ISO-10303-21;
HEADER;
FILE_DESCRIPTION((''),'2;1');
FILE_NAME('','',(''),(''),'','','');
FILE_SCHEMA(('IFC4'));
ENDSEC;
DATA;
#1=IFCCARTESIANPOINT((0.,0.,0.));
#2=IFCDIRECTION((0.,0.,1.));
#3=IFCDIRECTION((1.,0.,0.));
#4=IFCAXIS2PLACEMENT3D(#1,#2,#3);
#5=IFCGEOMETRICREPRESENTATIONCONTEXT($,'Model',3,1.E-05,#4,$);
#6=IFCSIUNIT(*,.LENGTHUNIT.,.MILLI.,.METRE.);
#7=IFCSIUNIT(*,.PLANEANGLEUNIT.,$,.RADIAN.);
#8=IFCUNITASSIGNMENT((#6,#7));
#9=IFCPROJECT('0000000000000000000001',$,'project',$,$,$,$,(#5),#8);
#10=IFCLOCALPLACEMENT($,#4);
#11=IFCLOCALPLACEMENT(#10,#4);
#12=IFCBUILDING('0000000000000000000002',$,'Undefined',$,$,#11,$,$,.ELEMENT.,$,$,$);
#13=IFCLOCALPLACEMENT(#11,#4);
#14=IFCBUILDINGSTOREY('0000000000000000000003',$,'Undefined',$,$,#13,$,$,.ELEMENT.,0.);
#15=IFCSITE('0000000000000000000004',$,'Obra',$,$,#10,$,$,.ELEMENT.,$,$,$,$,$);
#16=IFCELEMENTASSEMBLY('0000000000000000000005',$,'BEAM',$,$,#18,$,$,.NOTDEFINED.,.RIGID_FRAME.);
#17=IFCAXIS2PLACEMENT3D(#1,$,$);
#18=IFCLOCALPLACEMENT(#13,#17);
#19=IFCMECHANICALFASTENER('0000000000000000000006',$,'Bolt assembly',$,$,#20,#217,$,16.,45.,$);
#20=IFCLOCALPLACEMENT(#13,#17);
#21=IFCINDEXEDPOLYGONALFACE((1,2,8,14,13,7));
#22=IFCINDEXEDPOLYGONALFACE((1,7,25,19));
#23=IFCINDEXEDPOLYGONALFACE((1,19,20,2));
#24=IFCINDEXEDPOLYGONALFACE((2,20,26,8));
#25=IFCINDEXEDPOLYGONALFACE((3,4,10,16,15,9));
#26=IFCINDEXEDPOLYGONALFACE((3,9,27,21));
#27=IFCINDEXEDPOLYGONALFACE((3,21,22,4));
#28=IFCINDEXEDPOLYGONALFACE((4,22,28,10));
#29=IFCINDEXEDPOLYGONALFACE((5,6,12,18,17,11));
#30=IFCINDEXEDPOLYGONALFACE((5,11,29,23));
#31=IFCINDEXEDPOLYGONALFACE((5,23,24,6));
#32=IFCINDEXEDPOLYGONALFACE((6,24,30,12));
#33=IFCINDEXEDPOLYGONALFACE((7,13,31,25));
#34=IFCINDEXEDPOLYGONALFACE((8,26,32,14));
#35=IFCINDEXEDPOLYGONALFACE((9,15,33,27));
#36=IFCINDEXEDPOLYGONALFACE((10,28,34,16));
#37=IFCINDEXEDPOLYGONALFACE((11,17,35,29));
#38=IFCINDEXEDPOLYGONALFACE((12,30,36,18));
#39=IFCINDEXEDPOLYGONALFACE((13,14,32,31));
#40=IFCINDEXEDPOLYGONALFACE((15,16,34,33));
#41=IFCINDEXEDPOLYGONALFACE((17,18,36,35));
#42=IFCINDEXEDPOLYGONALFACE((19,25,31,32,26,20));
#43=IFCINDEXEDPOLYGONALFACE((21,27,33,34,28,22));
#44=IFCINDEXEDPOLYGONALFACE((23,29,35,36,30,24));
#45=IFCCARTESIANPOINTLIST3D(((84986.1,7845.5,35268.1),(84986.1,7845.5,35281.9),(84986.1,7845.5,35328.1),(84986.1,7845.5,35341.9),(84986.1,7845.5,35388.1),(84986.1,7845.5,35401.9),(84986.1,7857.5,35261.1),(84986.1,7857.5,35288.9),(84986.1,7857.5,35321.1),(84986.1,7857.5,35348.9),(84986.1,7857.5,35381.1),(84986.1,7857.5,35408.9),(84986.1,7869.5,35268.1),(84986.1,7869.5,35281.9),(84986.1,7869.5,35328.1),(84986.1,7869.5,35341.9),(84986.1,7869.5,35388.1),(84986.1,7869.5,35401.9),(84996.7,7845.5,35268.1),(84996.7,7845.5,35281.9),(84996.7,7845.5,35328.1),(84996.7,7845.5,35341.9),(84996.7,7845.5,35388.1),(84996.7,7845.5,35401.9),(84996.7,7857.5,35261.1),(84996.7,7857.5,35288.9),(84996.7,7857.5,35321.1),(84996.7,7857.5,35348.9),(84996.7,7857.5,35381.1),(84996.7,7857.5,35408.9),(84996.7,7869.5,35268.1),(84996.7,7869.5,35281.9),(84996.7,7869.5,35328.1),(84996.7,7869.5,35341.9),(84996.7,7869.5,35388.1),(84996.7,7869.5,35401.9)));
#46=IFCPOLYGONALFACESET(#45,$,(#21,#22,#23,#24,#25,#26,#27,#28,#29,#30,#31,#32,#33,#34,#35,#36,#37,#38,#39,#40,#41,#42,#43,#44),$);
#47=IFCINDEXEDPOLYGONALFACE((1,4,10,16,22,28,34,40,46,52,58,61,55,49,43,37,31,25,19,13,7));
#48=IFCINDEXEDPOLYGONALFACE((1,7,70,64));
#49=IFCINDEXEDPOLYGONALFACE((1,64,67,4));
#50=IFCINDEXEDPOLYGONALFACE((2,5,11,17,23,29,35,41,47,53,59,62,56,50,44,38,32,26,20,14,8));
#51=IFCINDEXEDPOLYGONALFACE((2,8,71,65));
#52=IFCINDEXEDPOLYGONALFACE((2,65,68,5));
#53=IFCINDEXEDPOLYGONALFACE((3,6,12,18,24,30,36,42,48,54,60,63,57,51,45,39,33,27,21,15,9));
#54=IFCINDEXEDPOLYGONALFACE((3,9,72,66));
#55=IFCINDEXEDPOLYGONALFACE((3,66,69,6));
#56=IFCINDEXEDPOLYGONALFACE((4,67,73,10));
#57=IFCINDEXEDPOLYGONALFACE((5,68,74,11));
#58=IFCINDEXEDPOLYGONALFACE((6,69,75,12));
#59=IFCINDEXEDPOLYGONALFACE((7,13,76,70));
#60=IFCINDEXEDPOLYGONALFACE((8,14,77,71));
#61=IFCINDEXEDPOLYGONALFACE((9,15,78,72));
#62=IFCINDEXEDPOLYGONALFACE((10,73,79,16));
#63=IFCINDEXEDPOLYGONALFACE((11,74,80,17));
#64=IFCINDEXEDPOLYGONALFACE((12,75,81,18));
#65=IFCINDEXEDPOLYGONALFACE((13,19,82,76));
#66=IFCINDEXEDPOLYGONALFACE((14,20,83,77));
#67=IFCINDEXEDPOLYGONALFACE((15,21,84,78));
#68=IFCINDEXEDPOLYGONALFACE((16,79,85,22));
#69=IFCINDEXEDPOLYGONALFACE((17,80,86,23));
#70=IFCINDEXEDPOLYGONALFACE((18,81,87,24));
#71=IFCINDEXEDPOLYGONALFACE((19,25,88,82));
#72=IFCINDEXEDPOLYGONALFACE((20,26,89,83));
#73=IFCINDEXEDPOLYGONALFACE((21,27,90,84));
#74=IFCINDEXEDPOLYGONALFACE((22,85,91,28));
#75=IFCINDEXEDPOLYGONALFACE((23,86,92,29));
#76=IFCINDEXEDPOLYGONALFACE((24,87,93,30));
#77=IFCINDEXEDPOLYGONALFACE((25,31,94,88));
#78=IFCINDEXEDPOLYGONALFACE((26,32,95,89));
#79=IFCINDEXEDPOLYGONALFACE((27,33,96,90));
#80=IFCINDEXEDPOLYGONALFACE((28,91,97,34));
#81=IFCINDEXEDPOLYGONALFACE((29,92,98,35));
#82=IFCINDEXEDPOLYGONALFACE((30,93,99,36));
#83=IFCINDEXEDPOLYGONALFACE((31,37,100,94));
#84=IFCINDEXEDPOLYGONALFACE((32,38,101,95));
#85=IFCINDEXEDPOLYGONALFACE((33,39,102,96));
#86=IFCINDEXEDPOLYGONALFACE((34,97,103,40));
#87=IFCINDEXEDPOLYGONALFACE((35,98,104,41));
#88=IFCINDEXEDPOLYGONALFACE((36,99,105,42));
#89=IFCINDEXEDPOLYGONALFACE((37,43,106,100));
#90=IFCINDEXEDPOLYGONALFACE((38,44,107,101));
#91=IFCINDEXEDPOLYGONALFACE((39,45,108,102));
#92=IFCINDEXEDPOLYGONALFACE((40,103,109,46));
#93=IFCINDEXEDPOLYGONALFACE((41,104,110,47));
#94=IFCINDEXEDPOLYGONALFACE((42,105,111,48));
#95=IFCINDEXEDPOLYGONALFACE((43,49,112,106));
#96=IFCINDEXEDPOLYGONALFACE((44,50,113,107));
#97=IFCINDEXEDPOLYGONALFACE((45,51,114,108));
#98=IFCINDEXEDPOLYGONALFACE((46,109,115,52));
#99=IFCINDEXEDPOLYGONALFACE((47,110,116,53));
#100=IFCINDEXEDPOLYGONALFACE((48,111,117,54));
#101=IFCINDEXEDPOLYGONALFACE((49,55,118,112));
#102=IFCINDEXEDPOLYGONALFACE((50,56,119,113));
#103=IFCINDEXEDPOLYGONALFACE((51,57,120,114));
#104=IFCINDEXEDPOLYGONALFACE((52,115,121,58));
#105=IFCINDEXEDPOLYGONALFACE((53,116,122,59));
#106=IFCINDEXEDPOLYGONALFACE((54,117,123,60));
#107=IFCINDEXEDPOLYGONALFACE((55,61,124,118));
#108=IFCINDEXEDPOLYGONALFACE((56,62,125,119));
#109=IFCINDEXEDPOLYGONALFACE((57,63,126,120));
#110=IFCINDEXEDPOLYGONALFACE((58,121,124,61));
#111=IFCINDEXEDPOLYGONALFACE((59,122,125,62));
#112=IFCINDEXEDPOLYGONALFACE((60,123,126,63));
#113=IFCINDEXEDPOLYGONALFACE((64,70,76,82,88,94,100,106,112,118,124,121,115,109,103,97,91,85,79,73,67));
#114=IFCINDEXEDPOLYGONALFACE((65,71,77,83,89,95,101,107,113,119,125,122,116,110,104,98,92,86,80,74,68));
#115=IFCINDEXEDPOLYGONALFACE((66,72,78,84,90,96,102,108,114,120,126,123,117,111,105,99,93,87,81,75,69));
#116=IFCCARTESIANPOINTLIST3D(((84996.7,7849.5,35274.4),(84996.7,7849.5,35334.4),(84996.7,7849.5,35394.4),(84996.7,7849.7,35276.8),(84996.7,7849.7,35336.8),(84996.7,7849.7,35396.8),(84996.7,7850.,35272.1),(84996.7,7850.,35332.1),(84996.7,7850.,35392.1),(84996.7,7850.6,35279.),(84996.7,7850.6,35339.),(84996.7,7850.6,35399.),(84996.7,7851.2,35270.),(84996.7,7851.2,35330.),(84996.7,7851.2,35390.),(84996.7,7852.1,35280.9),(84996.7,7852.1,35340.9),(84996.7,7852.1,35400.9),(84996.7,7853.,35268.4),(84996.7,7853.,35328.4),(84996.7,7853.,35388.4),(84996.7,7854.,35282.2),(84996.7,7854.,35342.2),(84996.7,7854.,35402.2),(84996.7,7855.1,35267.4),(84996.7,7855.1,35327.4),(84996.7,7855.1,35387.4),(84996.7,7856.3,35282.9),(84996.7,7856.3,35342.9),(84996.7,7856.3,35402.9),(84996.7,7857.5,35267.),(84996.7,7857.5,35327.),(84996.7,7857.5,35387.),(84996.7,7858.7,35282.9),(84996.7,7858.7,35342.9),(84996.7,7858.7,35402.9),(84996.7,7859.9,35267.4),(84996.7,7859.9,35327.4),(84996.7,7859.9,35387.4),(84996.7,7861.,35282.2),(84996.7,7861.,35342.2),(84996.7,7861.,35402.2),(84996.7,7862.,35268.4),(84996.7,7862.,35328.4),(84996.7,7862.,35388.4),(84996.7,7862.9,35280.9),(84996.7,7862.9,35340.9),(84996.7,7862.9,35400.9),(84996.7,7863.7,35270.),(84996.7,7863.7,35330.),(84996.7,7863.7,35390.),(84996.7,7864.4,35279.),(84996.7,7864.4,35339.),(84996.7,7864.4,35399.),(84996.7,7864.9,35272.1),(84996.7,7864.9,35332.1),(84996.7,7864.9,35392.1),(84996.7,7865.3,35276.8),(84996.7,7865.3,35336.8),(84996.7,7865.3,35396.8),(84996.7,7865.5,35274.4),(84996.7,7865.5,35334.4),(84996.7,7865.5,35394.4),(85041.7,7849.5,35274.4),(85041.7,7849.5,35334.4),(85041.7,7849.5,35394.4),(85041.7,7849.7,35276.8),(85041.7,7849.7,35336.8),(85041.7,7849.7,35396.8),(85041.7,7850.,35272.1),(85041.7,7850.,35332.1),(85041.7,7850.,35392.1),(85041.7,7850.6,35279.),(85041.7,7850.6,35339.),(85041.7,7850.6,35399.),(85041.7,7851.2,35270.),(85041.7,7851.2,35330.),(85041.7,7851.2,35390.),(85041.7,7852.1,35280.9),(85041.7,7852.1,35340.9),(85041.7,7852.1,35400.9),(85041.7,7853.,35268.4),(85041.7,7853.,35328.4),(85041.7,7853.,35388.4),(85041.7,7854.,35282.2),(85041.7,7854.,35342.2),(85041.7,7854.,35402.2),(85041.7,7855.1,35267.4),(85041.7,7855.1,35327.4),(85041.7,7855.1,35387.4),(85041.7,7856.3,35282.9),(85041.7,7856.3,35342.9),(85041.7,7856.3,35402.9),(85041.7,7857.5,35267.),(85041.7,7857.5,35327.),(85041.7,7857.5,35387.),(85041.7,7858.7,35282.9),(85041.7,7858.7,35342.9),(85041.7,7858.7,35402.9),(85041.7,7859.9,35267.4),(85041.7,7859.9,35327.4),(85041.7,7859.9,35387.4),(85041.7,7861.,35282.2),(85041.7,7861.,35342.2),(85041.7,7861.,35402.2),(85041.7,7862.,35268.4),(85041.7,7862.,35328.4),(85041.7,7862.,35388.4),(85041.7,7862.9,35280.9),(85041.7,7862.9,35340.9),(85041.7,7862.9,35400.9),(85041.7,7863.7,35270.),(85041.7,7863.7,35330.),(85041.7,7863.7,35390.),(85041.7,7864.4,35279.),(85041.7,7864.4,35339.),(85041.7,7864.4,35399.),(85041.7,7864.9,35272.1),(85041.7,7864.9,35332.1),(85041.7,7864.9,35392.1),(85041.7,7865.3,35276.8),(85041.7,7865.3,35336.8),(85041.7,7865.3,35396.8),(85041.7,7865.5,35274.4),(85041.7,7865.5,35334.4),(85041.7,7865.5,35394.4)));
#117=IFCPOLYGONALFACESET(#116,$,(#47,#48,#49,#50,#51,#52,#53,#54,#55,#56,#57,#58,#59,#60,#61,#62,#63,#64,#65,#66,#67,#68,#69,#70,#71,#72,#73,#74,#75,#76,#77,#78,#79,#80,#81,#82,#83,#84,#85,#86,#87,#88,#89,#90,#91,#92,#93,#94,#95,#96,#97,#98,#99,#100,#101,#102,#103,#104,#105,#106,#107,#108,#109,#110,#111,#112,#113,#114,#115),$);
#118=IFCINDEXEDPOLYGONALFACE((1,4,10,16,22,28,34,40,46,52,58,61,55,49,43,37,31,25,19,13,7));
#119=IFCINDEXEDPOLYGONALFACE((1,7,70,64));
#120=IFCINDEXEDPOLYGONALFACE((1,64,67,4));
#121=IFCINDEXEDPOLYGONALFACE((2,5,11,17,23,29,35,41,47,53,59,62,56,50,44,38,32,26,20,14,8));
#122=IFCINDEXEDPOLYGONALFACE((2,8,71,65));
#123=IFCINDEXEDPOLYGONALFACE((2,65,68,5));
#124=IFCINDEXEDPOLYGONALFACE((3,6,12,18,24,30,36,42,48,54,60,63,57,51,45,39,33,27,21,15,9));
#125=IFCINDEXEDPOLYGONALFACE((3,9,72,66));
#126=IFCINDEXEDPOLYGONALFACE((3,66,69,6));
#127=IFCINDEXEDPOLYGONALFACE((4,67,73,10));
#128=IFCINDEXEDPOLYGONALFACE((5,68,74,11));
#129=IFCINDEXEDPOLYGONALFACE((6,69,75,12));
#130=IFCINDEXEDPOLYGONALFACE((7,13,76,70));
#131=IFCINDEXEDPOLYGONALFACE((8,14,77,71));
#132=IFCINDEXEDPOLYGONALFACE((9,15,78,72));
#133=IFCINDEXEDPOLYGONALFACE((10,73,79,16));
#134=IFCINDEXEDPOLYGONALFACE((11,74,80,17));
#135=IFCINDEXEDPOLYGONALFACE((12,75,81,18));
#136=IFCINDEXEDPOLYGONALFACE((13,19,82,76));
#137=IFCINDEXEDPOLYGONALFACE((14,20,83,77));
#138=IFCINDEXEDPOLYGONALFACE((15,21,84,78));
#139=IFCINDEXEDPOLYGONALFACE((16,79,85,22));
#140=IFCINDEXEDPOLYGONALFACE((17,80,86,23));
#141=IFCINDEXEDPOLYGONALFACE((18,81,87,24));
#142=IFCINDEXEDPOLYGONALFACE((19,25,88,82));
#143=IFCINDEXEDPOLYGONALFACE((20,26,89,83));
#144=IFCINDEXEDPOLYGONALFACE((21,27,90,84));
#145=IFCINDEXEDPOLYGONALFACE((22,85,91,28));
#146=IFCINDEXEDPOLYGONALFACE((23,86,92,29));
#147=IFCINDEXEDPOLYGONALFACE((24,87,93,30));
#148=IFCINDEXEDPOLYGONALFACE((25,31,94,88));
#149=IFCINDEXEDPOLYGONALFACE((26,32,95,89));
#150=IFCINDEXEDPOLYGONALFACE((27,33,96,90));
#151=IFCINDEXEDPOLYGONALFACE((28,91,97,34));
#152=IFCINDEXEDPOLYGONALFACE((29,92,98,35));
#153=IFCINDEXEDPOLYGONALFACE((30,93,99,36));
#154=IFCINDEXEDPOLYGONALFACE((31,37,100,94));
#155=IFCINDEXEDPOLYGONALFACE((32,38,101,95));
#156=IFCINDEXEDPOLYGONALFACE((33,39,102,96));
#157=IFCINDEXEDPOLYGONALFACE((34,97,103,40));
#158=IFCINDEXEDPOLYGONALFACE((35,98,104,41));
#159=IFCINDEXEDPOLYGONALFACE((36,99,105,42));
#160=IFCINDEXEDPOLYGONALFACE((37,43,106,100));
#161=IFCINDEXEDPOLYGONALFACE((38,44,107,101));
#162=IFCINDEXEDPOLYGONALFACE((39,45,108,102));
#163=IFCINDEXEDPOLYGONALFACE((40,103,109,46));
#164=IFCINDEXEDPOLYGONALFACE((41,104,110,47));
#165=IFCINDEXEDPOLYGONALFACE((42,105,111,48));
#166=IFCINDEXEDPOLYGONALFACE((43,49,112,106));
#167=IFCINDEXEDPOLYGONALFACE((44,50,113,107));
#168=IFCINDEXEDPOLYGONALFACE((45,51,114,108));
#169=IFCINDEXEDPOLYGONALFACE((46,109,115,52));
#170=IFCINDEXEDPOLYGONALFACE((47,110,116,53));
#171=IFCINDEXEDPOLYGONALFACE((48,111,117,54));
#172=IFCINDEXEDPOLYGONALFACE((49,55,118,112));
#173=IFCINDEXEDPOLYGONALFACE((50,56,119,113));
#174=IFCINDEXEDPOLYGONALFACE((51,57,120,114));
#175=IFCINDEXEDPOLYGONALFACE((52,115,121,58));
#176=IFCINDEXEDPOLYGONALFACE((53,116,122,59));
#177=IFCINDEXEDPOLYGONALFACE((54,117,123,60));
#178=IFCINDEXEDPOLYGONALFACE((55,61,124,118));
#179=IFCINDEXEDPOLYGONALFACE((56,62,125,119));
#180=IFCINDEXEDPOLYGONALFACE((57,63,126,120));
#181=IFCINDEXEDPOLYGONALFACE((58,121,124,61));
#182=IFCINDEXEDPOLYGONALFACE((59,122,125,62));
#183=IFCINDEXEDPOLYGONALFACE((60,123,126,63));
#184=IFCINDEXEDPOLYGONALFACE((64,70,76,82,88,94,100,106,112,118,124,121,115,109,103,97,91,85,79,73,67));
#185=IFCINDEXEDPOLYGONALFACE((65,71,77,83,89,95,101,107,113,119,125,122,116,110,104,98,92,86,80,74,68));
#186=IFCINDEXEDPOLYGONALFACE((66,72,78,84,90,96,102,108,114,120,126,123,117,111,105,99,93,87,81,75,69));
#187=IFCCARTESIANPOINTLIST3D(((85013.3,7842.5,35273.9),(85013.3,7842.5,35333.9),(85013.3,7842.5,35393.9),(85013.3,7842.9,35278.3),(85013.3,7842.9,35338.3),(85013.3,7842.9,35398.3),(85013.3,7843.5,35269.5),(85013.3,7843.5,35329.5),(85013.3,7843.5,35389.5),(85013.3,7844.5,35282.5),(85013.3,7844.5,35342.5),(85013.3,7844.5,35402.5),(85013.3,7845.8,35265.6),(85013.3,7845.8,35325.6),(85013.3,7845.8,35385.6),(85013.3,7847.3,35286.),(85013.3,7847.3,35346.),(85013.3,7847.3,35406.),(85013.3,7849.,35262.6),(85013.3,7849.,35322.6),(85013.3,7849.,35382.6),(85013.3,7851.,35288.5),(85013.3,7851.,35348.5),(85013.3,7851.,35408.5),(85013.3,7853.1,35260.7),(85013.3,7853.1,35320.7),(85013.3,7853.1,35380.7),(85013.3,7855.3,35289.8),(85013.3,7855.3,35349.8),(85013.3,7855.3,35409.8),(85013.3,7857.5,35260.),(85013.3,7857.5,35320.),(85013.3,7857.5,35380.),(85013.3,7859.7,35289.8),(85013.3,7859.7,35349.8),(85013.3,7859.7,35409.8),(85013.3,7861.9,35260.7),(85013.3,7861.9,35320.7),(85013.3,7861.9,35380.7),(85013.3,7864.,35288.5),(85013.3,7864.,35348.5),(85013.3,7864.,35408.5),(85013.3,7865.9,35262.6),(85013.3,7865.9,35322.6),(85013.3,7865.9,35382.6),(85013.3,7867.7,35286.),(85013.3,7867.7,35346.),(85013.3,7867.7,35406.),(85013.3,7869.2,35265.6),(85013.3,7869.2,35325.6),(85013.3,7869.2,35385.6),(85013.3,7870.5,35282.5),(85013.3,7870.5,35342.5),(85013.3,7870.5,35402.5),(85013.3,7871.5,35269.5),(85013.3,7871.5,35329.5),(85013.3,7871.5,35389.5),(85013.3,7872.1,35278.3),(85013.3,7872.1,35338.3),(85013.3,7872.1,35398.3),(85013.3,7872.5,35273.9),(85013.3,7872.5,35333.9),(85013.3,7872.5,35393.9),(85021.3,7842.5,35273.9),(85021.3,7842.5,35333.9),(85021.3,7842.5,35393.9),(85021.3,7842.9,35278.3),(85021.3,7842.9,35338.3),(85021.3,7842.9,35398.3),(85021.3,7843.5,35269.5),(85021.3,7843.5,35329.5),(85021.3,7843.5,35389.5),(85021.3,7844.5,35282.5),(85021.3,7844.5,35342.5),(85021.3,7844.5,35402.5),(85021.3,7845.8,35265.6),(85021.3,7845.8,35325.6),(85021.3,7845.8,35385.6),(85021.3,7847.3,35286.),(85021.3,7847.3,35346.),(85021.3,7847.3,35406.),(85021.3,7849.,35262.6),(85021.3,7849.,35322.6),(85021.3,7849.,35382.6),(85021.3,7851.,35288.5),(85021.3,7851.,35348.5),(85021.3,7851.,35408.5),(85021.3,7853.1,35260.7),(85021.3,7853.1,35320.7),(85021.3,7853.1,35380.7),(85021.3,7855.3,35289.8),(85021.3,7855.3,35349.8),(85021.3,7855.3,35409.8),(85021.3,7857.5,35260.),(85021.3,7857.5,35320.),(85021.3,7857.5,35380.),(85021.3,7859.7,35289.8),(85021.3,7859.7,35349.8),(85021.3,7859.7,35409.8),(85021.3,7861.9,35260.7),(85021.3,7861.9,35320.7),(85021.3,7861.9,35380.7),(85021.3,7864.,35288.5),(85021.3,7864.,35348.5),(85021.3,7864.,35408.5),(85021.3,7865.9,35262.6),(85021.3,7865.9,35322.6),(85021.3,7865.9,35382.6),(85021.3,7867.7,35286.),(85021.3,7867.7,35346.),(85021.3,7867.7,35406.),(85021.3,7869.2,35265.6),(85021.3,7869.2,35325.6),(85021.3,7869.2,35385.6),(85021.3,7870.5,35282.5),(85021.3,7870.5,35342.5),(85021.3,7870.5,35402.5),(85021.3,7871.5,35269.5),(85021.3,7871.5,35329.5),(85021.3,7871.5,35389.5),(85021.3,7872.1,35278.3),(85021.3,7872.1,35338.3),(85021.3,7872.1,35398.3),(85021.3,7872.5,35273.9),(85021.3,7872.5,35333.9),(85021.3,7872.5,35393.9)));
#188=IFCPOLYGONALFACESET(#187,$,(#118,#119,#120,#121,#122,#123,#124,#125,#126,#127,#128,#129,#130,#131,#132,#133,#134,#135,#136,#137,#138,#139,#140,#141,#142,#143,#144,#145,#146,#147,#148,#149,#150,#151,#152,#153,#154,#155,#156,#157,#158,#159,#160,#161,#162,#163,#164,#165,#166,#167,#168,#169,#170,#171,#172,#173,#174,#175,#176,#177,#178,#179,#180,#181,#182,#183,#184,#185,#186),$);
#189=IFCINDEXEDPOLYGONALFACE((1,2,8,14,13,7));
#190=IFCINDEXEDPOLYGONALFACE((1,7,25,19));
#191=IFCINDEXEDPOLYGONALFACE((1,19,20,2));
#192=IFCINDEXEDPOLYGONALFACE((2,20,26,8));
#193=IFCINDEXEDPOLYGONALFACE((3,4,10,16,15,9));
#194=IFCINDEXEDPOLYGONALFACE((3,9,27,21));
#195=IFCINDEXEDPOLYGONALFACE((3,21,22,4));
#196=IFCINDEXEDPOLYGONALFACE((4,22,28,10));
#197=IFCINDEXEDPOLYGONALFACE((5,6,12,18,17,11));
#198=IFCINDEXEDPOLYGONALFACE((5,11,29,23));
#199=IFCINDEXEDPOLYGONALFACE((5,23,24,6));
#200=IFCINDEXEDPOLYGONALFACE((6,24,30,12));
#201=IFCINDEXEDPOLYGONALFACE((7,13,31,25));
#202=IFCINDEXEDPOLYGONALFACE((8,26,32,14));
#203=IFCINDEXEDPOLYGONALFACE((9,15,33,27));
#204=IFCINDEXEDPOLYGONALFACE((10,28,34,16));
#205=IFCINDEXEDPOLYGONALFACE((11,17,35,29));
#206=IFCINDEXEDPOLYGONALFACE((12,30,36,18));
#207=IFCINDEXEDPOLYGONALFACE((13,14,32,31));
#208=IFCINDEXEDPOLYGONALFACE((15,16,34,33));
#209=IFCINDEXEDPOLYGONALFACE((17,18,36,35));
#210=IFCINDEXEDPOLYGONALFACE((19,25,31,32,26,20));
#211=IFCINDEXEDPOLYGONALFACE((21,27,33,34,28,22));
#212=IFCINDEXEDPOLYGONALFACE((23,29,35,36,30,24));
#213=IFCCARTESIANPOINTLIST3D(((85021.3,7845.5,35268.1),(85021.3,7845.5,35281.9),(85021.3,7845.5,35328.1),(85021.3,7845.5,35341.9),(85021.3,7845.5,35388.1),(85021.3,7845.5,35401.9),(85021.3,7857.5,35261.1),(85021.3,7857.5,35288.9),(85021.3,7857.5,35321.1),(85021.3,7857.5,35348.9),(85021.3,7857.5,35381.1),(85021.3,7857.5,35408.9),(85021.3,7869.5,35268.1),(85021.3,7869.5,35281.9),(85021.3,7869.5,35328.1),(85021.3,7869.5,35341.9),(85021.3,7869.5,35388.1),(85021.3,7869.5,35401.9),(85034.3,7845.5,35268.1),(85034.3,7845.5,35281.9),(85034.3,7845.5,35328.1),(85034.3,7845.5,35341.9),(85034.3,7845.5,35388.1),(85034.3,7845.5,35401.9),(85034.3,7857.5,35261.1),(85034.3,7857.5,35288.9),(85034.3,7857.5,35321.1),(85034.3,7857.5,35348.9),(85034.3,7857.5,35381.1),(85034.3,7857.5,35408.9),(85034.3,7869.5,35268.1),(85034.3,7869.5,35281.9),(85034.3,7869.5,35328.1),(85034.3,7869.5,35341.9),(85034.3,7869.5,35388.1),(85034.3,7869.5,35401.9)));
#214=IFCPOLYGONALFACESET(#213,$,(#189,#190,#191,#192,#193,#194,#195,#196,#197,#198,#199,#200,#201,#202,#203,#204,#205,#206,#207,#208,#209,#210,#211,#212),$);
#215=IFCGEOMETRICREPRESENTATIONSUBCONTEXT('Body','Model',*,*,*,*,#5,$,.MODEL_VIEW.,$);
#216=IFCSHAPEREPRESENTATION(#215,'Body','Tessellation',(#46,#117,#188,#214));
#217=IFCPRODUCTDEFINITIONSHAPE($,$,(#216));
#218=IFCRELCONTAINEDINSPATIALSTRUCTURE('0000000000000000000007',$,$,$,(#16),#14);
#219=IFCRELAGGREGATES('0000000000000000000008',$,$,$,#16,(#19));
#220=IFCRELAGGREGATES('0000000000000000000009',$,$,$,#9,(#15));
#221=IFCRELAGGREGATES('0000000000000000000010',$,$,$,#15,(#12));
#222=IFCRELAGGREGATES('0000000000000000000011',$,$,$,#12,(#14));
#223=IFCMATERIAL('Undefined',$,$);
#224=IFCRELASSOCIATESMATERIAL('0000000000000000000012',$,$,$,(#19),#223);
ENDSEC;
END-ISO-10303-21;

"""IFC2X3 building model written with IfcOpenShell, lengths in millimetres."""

from ifc_helpers import new_model, si_unit, frame, origin_with_axes, origin_2d_with_axis, place, context, subcontext, project, spatial, polyline, circle, outline, extrude, source, transform, mapped, material, element, aggregate, save


model = new_model("IFC2X3")

# Units and contexts
model_context = context("Model", 3, precision=1e-05, world=origin_with_axes())
body_context = subcontext(model_context, "Body", "Model", "MODEL_VIEW")
ifc_project = project(units=[si_unit("LENGTHUNIT", "METRE", prefix="MILLI"), si_unit("PLANEANGLEUNIT", "RADIAN")], contexts=[model_context])

# Site, building, storey
site_placement = place(None, origin_with_axes())
site = spatial("IfcSite", under=ifc_project, at=site_placement, Name="Obra", CompositionType="ELEMENT")
building_placement = place(site_placement, origin_with_axes())
building = spatial("IfcBuilding", under=site, at=building_placement, Name="Undefined", CompositionType="ELEMENT")
storey_placement = place(building_placement, origin_with_axes())
storey = spatial("IfcBuildingStorey", under=building, at=storey_placement, Name="Undefined", CompositionType="ELEMENT", Elevation=0.0)

# Element assembly
assembly_1_placement = place(storey_placement, origin_with_axes())
assembly_1 = element("IfcElementAssembly", 1, at=assembly_1_placement, inside=storey, Name="BEAM", AssemblyPlace="NOTDEFINED", PredefinedType="RIGID_FRAME")

# Shared definitions
ifc_material_1 = material(Name="Undefined")

# Mechanical fastener
shared_shape_1 = source(origin_with_axes(), body_context, "Body", "SweptSolid", [
    extrude(outline(polyline([(13.9, 0.0), (6.9, 12.0), (-6.9, 12.0), (-13.9, 0.0), (-6.9, -12.0), (6.9, -12.0), (13.9, 0.0)])), frame((0.0, -13.9, 0.0), z_axis=(0.0, 1.0, 0.0), x_axis=(1.0, 0.0, 0.0)), (0.0, 0.0, 1.0), 10.6),
    extrude(circle(Radius=8.0, at=origin_2d_with_axis()), frame((0.0, -3.3, 0.0), z_axis=(0.0, 1.0, 0.0), x_axis=(1.0, 0.0, 0.0)), (0.0, 0.0, 1.0), 45.0),
    extrude(circle(Radius=15.0, at=origin_2d_with_axis()), frame((0.0, 13.3, 0.0), z_axis=(0.0, 1.0, 0.0), x_axis=(1.0, 0.0, 0.0)), (0.0, 0.0, 1.0), 8.0),
    extrude(outline(polyline([(13.9, 0.0), (6.9, 12.0), (-6.9, 12.0), (-13.9, 0.0), (-6.9, -12.0), (6.9, -12.0), (13.9, 0.0)])), frame((0.0, 21.3, 0.0), z_axis=(0.0, 1.0, 0.0), x_axis=(1.0, 0.0, 0.0)), (0.0, 0.0, 1.0), 13.0),
])
mechanical_fastener_1_placement = place(assembly_1_placement, frame((85000.0, 7907.5, 35470.0), z_axis=(0.0, -1.0, 0.0), x_axis=(0.0, 0.0, -1.0)))
mechanical_fastener_1 = element("IfcMechanicalFastener", 2, at=mechanical_fastener_1_placement, material=ifc_material_1, Name="Bolt assembly", NominalDiameter=16.0, NominalLength=45.0, context=body_context, shape_type="MappedRepresentation", body=[
    mapped(shared_shape_1, transform((75.0, 0.0, 50.0))),
    mapped(shared_shape_1, transform((135.0, 0.0, 50.0))),
    mapped(shared_shape_1, transform((195.0, 0.0, 50.0))),
])
aggregate(assembly_1, [mechanical_fastener_1])

save(model, "model.ifc")
